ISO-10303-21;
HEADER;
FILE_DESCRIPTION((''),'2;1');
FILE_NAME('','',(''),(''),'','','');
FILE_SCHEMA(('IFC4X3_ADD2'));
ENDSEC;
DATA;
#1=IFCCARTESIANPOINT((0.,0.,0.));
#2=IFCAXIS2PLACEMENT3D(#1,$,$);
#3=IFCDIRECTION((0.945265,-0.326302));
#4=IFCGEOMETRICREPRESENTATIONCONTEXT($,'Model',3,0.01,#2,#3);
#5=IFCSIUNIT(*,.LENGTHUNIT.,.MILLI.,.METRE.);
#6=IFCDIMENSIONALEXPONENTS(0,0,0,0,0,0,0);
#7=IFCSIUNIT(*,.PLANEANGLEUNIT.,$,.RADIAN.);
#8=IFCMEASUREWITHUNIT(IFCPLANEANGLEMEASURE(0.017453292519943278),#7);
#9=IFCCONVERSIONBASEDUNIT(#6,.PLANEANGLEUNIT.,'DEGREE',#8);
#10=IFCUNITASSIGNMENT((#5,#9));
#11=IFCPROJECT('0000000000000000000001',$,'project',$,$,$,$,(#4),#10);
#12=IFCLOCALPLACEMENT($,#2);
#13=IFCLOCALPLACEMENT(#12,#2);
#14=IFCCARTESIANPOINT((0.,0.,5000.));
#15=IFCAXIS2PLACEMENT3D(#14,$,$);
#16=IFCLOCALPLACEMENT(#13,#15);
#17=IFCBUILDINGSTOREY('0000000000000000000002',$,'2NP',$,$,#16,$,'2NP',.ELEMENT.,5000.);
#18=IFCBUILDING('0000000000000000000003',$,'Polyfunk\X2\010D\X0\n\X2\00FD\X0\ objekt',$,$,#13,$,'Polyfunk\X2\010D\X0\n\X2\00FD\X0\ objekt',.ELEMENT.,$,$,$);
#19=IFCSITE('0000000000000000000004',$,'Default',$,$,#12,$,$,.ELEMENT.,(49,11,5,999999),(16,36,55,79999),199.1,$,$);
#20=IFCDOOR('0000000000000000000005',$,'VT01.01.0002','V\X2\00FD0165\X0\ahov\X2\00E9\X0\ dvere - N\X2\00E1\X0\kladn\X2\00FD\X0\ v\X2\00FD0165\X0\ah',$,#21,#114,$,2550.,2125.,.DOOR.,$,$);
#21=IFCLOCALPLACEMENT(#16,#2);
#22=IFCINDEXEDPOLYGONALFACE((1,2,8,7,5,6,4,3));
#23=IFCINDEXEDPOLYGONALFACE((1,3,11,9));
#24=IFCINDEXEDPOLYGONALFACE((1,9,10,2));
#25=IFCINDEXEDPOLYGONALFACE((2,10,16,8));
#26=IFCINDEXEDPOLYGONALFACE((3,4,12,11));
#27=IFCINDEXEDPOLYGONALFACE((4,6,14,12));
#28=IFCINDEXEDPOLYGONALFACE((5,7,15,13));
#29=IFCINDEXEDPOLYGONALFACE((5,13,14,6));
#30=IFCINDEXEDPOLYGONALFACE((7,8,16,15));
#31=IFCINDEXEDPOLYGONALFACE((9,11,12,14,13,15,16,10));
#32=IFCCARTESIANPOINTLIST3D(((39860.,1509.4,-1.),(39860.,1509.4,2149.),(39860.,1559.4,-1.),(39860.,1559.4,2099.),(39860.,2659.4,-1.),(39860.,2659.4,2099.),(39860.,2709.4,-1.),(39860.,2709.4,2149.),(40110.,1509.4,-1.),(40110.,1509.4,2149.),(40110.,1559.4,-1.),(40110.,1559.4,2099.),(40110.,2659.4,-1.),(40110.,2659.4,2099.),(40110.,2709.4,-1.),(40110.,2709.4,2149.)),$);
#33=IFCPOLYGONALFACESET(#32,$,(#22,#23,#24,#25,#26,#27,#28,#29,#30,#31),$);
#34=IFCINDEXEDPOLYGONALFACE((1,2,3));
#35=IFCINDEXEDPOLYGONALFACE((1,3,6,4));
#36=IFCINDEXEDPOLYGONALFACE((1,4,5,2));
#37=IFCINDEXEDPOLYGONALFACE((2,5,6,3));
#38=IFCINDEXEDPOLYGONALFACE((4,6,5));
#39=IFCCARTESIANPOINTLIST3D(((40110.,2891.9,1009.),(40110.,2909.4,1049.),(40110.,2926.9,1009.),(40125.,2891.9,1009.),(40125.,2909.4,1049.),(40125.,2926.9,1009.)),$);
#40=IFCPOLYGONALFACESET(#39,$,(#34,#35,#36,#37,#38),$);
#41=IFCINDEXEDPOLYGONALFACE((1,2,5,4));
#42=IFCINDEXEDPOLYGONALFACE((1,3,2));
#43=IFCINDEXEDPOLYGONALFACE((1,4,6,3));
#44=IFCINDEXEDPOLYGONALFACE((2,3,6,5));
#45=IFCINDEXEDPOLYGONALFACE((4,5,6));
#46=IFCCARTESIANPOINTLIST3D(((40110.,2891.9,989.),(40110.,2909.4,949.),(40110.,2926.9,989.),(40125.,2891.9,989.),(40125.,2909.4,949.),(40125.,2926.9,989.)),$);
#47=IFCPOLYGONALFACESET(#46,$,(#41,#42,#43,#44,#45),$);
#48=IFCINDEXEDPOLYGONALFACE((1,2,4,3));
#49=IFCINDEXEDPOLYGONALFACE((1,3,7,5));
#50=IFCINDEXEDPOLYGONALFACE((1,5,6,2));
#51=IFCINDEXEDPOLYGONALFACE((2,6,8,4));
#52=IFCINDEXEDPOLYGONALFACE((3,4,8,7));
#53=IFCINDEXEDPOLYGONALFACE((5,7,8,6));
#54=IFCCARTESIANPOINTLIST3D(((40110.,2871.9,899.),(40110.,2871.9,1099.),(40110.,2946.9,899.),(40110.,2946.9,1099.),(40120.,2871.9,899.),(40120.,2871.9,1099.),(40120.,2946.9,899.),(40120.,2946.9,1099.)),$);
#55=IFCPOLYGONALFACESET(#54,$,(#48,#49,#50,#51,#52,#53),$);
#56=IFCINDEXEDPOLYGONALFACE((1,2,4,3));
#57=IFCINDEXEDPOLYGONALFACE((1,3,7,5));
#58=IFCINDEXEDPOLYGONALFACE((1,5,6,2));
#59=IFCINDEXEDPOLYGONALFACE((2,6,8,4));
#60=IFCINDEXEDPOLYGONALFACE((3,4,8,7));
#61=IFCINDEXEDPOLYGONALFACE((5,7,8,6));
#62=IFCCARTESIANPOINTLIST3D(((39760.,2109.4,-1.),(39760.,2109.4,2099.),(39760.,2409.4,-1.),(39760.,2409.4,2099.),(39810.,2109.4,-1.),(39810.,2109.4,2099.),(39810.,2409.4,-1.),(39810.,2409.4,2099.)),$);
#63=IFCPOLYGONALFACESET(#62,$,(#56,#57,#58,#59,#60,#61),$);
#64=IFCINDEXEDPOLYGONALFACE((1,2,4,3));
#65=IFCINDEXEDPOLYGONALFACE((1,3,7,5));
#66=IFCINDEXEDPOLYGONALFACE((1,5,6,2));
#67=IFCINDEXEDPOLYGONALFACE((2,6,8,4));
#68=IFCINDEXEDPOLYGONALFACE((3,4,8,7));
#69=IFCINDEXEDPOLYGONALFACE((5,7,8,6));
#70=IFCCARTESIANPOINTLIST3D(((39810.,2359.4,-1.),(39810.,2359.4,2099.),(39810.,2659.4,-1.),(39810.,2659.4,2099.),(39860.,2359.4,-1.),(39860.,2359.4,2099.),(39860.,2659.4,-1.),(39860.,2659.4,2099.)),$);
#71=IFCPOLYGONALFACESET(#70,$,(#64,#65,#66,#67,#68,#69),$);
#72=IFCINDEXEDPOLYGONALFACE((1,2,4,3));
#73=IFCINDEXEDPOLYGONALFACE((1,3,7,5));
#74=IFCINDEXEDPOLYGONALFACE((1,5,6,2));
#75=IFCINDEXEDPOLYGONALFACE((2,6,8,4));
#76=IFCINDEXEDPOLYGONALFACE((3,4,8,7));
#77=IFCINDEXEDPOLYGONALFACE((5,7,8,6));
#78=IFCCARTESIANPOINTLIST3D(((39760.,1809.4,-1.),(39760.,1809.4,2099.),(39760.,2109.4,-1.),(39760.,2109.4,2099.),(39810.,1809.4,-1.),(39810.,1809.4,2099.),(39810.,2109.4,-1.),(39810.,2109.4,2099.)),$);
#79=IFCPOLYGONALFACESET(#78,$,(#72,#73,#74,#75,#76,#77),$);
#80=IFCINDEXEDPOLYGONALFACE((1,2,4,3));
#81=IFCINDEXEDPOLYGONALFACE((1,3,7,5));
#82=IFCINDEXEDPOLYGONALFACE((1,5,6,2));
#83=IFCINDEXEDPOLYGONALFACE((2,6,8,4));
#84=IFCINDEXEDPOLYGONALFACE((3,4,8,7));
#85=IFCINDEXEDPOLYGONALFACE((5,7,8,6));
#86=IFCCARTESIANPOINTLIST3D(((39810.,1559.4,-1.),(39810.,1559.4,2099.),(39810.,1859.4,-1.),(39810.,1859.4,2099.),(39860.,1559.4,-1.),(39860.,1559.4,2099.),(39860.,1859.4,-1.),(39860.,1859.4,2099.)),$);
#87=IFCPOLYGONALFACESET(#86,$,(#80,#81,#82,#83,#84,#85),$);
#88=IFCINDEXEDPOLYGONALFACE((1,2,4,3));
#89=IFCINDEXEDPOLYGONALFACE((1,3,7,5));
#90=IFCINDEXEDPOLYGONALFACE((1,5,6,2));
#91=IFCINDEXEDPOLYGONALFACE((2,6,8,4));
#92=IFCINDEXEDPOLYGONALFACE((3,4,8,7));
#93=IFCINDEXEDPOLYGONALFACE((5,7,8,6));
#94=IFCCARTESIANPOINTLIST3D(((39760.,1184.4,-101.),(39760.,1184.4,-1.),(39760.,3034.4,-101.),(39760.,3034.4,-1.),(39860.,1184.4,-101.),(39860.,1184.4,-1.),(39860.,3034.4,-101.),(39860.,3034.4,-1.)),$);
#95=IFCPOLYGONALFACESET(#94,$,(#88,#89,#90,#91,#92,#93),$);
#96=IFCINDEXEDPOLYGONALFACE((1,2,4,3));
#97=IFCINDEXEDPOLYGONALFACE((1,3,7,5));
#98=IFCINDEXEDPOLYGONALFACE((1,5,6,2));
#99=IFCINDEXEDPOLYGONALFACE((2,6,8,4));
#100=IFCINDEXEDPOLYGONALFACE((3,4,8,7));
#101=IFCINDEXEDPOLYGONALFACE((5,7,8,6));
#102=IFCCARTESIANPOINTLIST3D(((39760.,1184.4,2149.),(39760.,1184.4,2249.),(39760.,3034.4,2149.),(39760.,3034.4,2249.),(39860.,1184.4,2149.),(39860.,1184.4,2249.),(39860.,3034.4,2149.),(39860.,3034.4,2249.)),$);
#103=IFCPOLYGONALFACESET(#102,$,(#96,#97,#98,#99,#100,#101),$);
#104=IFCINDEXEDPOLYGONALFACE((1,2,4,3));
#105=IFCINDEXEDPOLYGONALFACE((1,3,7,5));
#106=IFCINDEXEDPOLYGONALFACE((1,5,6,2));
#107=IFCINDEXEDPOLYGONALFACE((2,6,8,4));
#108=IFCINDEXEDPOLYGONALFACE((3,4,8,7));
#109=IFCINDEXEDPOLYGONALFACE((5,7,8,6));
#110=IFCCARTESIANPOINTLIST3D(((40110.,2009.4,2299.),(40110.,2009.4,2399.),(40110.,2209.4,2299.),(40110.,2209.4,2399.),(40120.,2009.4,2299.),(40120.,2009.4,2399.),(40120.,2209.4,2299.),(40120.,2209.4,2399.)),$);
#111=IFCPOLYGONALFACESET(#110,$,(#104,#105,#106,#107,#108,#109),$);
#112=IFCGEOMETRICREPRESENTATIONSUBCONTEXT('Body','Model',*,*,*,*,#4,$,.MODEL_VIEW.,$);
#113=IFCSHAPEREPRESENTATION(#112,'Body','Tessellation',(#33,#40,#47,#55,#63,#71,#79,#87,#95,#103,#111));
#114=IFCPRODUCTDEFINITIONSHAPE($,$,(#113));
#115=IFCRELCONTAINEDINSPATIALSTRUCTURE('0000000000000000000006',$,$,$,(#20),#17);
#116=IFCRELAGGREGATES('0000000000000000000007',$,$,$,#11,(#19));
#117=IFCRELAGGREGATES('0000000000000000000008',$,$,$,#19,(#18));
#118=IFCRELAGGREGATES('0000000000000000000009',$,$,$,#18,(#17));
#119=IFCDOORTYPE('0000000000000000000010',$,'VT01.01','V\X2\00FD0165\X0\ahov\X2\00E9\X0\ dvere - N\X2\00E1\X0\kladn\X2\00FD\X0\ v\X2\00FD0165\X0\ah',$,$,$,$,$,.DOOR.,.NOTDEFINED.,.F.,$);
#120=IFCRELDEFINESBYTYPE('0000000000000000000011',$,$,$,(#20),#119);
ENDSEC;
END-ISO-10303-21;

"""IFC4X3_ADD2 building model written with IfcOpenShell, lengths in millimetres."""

from ifc_helpers import new_model, entity, si_unit, converted_unit, direction, frame, frame_2d, origin, origin_2d_with_axis, place, context, subcontext, project, spatial, polyline, rectangle, outline, extrude, source, transform, mapped, type_object, type_shapes, element, save


model = new_model("IFC4X3_ADD2")

# Units and contexts
model_context = context("Model", 3, precision=0.01, world=origin(), true_north=direction((0.945265, -0.326302)))
body_context = subcontext(model_context, "Body", "Model", "MODEL_VIEW")
ifc_project = project(units=[si_unit("LENGTHUNIT", "METRE", prefix="MILLI"), converted_unit("PLANEANGLEUNIT", "DEGREE", entity("IfcPlaneAngleMeasure", 0.017453292519943278), si_unit("PLANEANGLEUNIT", "RADIAN"), dimensions=[0, 0, 0, 0, 0, 0, 0])], contexts=[model_context])

# Site, building, storey
site_placement = place(None, origin())
site = spatial("IfcSite", under=ifc_project, at=site_placement, Name="Default", CompositionType="ELEMENT", RefLatitude=(49, 11, 5, 999999), RefLongitude=(16, 36, 55, 79999), RefElevation=199.1)
building_placement = place(site_placement, origin())
building = spatial("IfcBuilding", under=site, at=building_placement, Name="Polyfunkčný objekt", LongName="Polyfunkčný objekt", CompositionType="ELEMENT")
storey_placement = place(building_placement, frame((0.0, 0.0, 5000.0)))
storey = spatial("IfcBuildingStorey", under=building, at=storey_placement, Name="2NP", LongName="2NP", CompositionType="ELEMENT", Elevation=5000.0)

# Door
door_type = type_object("IfcDoorType", Name="VT01.01", Description="Výťahové dvere - Nákladný výťah", OperationType="NOTDEFINED", ParameterTakesPrecedence=False, PredefinedType="DOOR")
shared_shape_1 = source(origin(), body_context, "Body", "SweptSolid", [
    extrude(outline(polyline([(-1087.5, -600.0), (1062.5, -600.0), (1062.5, -550.0), (-1037.5, -550.0), (-1037.5, 550.0), (1062.5, 550.0), (1062.5, 600.0), (-1087.5, 600.0), (-1087.5, -600.0)])), frame((600.0, 0.0, 1062.5), z_axis=(0.0, 1.0, 0.0), x_axis=(0.0, 0.0, -1.0)), (0.0, 0.0, 1.0), 250.0),
    extrude(outline(polyline([(-24.4, -10.7), (19.2, -10.7), (5.2, 21.4), (-24.4, -10.7)])), frame((1400.0, -15.0, 1023.3), z_axis=(0.0, 1.0, 0.0), x_axis=(0.400819, 0.0, -0.916157)), (0.0, 0.0, 1.0), 15.0),
    extrude(outline(polyline([(-24.4, -10.7), (19.2, -10.7), (5.2, 21.4), (-24.4, -10.7)])), frame((1400.0, -15.0, 976.7), z_axis=(0.0, 1.0, 0.0), x_axis=(-0.400819, 0.0, 0.916157)), (0.0, 0.0, 1.0), 15.0),
    extrude(rectangle(XDim=10.0, YDim=75.0, at=frame_2d((0.0, 0.0), x_axis=(1.0, 0.0))), frame((1400.0, -5.0, 900.0), z_axis=(0.0, 0.0, 1.0), x_axis=(0.0, 1.0, 0.0)), (0.0, 0.0, 1.0), 200.0),
    extrude(rectangle(XDim=50.0, YDim=300.0, at=origin_2d_with_axis()), frame((750.0, 325.0, 0.0), z_axis=(0.0, 0.0, 1.0), x_axis=(0.0, -1.0, 0.0)), (0.0, 0.0, 1.0), 2100.0),
    extrude(rectangle(XDim=50.0, YDim=300.0, at=frame_2d((0.0, 0.0), x_axis=(1.0, 0.0))), frame((1000.0, 275.0, 0.0), z_axis=(0.0, 0.0, 1.0), x_axis=(0.0, -1.0, 0.0)), (0.0, 0.0, 1.0), 2100.0),
    extrude(rectangle(XDim=300.0, YDim=50.0, at=frame_2d((0.0, 0.0), x_axis=(1.0, 0.0))), frame((450.0, 325.0, 0.0), z_axis=(0.0, 0.0, 1.0), x_axis=(-1.0, 0.0, 0.0)), (0.0, 0.0, 1.0), 2100.0),
    extrude(rectangle(XDim=300.0, YDim=50.0, at=frame_2d((0.0, 0.0), x_axis=(1.0, 0.0))), frame((200.0, 275.0, 0.0), z_axis=(0.0, 0.0, 1.0), x_axis=(-1.0, 0.0, 0.0)), (0.0, 0.0, 1.0), 2100.0),
    extrude(rectangle(XDim=1850.0, YDim=100.0, at=frame_2d((0.0, 0.0), x_axis=(1.0, 0.0))), frame((600.0, 300.0, -100.0), z_axis=(0.0, 0.0, 1.0), x_axis=(-1.0, 0.0, 0.0)), (0.0, 0.0, 1.0), 100.0),
    extrude(rectangle(XDim=1850.0, YDim=100.0, at=frame_2d((0.0, 0.0), x_axis=(1.0, 0.0))), frame((600.0, 300.0, 2150.0), z_axis=(0.0, 0.0, 1.0), x_axis=(-1.0, 0.0, 0.0)), (0.0, 0.0, 1.0), 100.0),
    extrude(rectangle(XDim=10.0, YDim=200.0, at=frame_2d((0.0, 0.0), x_axis=(1.0, 0.0))), frame((600.0, -5.0, 2300.0), z_axis=(0.0, 0.0, 1.0), x_axis=(0.0, 1.0, 0.0)), (0.0, 0.0, 1.0), 100.0),
])
type_shapes(door_type, [shared_shape_1])
door_placement = place(storey_placement, frame((40110.0, 1509.4, -1.0), z_axis=(0.0, 0.0, 1.0), x_axis=(0.0, 1.0, 0.0)))
element("IfcDoor", 1, at=door_placement, inside=storey, type_object=door_type, Name="VT01.01.0002", Description="Výťahové dvere - Nákladný výťah", OverallHeight=2550.0, OverallWidth=2125.0, PredefinedType="DOOR", context=body_context, shape_type="MappedRepresentation", body=[
    mapped(shared_shape_1, transform((0.0, 0.0, 0.0), scale=1.0)),
])

save(model, "model.ifc")
